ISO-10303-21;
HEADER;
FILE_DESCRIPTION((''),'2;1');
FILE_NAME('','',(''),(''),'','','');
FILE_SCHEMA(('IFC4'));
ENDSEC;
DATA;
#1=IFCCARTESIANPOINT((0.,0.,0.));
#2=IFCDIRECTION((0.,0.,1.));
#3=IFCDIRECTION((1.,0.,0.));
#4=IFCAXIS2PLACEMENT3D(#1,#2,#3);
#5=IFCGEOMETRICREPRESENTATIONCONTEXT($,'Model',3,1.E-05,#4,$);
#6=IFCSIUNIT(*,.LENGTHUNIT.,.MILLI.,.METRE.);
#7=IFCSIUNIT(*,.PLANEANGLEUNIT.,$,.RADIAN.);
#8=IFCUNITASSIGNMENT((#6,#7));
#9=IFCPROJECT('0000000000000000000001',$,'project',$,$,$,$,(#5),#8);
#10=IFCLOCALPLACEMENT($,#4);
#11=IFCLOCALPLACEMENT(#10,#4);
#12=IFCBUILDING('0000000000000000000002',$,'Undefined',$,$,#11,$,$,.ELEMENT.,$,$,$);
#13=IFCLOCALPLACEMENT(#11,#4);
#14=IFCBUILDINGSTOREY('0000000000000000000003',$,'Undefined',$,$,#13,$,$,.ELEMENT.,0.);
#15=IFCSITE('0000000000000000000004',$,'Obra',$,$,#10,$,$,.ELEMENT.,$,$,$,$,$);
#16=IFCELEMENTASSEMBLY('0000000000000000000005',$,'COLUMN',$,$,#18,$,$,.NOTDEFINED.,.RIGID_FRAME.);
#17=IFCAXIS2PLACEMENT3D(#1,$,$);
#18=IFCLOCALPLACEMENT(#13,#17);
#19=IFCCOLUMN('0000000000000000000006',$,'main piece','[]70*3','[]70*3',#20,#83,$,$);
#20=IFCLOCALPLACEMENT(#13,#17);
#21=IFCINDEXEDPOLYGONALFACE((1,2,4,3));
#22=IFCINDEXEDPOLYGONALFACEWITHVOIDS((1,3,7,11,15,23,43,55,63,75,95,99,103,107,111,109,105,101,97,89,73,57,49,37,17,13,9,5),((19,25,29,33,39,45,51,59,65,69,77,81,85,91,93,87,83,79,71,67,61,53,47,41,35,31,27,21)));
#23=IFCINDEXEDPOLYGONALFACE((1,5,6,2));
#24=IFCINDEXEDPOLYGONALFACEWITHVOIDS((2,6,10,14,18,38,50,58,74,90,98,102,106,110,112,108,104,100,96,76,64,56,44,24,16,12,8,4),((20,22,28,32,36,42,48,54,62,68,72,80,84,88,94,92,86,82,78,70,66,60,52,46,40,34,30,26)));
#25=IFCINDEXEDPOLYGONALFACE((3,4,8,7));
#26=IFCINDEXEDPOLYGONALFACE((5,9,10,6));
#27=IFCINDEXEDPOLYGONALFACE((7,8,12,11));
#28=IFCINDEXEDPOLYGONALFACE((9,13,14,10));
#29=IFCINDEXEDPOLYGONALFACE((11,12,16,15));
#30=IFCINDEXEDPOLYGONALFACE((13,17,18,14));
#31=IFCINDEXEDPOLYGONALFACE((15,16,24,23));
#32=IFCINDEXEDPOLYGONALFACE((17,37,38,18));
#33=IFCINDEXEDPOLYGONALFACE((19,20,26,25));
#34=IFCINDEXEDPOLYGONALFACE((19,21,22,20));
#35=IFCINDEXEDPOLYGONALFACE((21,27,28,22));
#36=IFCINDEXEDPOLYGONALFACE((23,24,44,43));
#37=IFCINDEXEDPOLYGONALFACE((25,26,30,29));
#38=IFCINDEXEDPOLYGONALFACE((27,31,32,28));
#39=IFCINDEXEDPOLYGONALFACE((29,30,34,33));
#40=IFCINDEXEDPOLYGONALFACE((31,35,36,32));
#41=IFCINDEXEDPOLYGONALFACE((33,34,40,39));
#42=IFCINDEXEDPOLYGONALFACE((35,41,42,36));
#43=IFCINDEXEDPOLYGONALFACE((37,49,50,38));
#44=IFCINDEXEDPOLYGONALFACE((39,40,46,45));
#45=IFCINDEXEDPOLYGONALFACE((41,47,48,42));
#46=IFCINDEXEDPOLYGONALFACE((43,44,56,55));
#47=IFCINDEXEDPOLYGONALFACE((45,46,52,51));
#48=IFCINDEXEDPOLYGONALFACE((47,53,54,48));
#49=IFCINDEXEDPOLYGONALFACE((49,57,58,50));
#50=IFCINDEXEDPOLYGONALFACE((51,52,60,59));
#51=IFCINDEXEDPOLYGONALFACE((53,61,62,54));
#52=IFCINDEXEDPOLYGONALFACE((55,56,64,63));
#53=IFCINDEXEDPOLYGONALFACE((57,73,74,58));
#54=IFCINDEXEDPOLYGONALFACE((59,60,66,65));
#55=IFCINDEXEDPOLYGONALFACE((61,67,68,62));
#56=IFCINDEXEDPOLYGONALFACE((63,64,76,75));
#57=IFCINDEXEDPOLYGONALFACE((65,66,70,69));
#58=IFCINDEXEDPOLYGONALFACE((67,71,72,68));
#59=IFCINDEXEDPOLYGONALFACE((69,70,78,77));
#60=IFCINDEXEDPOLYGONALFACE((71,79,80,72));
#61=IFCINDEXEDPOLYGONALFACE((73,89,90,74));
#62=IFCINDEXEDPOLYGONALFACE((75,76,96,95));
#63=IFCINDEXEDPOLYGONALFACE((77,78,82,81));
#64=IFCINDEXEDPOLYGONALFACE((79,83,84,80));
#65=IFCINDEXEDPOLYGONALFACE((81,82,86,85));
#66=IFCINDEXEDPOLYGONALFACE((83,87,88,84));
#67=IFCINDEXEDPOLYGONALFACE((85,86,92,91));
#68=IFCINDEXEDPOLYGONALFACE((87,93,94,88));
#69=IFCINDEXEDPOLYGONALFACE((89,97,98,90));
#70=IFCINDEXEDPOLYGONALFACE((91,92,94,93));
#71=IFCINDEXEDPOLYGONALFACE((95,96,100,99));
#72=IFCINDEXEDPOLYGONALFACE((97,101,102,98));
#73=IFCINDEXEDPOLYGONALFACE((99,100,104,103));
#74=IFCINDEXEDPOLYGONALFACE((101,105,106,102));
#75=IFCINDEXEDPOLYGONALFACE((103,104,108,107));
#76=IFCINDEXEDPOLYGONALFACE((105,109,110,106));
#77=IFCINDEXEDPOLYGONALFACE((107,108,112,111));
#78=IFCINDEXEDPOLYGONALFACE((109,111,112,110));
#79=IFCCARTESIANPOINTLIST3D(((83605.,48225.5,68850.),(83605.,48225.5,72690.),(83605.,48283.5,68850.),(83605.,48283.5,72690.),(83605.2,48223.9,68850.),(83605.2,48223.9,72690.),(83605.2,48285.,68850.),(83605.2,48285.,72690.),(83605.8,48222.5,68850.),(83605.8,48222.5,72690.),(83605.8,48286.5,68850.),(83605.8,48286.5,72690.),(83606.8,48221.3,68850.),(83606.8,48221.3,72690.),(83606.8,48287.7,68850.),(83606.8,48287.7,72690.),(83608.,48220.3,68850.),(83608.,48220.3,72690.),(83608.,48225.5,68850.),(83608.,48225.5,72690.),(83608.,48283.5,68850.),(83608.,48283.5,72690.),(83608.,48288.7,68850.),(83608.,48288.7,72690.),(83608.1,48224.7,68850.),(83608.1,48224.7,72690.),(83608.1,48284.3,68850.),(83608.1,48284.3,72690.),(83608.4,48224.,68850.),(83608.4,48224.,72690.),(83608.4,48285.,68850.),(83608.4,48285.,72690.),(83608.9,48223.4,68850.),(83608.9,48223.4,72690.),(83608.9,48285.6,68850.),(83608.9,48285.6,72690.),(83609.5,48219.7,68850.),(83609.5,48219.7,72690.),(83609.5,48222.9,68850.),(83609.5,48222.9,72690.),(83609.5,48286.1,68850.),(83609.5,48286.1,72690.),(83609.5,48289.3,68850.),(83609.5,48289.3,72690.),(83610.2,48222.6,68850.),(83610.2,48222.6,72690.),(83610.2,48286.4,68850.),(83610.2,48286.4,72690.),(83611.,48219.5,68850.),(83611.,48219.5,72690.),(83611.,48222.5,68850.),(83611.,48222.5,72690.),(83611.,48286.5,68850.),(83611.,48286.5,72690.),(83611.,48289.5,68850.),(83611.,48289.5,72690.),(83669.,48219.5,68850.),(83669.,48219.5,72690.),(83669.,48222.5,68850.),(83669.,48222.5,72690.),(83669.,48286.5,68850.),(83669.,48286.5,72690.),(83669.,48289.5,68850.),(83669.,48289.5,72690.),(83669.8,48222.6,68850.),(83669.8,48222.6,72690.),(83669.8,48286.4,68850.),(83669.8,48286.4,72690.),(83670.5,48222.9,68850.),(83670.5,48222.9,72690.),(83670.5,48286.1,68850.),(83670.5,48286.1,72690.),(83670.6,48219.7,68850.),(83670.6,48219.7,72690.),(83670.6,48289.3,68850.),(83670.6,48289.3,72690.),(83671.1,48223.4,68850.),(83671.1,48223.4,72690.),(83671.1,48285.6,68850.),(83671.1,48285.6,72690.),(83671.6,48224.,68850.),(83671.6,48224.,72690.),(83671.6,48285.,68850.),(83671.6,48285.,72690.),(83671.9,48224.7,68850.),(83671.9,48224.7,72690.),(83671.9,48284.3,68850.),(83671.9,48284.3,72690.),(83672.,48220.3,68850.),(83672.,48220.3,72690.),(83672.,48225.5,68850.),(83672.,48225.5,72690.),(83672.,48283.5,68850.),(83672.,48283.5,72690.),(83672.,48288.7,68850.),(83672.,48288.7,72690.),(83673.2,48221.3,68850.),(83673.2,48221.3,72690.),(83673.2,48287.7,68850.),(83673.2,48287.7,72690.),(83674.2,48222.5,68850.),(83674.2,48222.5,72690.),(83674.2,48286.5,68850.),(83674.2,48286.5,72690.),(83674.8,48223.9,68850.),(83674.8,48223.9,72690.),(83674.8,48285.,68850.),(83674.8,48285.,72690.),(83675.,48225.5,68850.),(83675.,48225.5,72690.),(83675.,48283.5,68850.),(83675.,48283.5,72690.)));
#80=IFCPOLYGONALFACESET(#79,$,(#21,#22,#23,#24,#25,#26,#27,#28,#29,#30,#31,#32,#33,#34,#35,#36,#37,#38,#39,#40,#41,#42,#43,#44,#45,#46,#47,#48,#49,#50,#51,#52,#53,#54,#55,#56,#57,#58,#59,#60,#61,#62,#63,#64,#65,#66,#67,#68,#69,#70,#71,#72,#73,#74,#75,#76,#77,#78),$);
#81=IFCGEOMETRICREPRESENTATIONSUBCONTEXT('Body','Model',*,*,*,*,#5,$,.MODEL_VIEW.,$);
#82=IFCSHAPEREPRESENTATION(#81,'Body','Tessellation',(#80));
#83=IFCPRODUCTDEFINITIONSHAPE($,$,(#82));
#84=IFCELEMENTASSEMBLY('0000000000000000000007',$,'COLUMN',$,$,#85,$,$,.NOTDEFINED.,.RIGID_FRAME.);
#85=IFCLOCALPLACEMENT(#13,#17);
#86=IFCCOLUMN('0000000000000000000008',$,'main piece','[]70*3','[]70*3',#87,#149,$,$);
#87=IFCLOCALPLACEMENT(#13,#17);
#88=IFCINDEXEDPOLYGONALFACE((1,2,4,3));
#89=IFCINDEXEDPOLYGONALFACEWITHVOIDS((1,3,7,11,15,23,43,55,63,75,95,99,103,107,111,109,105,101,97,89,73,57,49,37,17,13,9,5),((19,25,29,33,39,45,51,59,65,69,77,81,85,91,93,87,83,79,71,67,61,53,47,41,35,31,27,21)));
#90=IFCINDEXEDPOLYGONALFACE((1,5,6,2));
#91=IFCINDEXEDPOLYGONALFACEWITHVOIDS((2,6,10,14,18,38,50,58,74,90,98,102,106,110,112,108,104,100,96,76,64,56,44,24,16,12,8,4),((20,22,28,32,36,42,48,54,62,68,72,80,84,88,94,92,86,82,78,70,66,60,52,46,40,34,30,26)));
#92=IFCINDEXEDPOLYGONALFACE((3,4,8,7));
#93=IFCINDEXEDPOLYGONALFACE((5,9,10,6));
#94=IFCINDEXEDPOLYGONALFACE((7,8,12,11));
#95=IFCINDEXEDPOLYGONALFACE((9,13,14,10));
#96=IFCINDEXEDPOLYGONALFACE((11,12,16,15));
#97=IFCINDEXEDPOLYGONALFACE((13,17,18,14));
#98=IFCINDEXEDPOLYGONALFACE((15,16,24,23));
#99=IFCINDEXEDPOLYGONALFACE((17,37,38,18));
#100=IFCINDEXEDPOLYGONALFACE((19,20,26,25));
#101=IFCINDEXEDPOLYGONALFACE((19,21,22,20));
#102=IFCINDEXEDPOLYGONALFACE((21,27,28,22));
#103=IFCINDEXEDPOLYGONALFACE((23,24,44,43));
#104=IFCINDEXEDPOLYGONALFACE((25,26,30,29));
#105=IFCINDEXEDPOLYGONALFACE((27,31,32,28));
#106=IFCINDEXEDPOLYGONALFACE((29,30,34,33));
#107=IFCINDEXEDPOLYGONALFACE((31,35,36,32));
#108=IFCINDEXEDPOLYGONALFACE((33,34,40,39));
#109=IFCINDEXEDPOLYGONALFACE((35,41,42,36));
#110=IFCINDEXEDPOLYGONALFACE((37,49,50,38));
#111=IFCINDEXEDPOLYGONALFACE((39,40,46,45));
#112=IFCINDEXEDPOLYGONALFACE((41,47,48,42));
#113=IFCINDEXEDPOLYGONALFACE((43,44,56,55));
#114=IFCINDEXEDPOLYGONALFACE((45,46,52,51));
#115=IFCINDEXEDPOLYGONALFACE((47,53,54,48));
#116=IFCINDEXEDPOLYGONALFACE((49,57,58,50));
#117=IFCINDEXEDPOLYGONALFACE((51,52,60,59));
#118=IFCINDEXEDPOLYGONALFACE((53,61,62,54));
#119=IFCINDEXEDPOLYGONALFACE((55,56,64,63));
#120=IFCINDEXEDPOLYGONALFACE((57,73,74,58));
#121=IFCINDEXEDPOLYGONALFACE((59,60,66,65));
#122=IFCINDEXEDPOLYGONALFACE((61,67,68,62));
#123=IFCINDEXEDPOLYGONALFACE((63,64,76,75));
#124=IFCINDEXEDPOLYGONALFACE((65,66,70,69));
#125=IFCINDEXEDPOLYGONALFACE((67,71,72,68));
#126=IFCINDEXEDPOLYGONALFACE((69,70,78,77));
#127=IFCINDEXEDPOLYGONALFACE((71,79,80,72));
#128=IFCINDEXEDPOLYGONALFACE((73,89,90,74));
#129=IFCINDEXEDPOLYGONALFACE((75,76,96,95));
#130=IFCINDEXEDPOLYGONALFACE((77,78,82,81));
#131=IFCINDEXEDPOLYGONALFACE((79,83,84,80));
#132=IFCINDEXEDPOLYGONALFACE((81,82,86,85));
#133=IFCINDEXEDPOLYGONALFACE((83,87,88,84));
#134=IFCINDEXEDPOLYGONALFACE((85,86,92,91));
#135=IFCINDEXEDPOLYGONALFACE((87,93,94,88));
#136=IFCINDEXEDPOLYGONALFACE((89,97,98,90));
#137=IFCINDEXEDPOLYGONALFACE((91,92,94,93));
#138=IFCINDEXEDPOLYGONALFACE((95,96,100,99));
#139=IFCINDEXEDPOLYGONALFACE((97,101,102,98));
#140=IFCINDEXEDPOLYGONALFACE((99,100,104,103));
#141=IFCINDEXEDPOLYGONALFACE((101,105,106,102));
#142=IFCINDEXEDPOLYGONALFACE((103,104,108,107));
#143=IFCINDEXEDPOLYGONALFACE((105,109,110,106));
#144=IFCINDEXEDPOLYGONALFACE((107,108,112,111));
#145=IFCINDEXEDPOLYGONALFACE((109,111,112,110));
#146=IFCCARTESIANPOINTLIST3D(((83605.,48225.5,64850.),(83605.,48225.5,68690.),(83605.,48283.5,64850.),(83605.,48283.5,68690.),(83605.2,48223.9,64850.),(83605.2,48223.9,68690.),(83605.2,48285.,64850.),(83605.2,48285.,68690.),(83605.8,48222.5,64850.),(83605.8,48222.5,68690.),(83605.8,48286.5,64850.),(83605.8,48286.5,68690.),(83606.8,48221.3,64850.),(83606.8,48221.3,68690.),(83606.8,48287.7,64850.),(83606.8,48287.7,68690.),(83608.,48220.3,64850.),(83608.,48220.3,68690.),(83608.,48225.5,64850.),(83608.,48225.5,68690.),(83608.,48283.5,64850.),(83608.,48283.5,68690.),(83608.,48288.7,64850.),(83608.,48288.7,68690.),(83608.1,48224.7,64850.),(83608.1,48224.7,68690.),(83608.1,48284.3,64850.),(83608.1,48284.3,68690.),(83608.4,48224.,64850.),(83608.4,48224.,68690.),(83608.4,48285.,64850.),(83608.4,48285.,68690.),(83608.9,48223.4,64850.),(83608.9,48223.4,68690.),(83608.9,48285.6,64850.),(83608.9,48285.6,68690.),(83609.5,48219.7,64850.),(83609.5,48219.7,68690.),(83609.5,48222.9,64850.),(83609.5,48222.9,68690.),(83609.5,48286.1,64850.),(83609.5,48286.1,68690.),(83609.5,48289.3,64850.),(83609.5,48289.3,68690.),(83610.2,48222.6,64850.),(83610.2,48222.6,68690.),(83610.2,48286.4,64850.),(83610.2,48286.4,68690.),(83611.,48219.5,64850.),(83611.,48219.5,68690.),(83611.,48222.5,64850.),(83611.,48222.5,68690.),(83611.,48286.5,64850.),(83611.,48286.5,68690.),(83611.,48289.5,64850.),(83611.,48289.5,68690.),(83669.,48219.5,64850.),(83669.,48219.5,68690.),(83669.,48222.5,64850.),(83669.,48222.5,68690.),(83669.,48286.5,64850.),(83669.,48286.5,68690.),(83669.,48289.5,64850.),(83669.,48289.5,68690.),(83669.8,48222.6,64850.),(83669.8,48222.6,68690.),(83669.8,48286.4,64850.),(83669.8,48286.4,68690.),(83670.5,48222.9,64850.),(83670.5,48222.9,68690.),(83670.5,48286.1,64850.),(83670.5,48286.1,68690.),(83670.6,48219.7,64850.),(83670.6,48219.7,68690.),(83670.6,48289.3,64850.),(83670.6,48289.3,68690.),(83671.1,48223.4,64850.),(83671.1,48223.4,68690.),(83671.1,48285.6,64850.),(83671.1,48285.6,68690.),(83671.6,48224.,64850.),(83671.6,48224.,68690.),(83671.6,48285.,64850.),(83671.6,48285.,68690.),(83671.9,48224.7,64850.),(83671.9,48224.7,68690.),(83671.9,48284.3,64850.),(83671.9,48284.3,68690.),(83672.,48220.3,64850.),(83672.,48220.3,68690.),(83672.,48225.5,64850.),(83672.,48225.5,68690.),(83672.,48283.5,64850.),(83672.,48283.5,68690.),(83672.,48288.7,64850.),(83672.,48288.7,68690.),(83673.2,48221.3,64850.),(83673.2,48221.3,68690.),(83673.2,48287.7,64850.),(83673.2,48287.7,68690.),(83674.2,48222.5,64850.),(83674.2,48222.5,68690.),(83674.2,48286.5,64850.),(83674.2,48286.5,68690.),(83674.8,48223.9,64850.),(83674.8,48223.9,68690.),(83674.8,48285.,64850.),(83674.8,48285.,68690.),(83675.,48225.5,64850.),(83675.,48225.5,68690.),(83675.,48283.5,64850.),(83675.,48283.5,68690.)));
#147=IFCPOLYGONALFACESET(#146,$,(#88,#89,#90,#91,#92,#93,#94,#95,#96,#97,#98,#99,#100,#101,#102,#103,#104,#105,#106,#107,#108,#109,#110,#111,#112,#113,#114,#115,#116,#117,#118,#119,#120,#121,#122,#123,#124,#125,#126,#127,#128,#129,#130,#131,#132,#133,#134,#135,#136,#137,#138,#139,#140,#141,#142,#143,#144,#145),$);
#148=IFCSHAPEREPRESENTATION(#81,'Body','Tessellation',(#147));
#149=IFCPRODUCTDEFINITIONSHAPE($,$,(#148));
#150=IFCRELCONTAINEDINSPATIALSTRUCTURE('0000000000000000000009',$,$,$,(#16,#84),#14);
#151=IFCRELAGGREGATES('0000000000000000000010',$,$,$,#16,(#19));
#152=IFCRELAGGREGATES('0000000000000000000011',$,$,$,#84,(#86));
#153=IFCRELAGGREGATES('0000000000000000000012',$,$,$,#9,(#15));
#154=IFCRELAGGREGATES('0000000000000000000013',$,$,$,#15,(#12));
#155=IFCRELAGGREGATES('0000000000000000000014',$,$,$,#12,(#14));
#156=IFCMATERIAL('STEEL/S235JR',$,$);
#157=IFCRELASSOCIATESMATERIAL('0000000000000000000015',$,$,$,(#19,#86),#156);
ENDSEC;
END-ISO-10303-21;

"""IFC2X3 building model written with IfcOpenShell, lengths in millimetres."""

from ifc_helpers import new_model, si_unit, frame, origin_with_axes, origin_2d_with_axis, place, context, subcontext, project, spatial, hollow_rectangle, extrude, material, element, aggregate, save


model = new_model("IFC2X3")

# Units and contexts
model_context = context("Model", 3, precision=1e-05, world=origin_with_axes())
body_context = subcontext(model_context, "Body", "Model", "MODEL_VIEW")
ifc_project = project(units=[si_unit("LENGTHUNIT", "METRE", prefix="MILLI"), si_unit("PLANEANGLEUNIT", "RADIAN")], contexts=[model_context])

# Site, building, storey
site_placement = place(None, origin_with_axes())
site = spatial("IfcSite", under=ifc_project, at=site_placement, Name="Obra", CompositionType="ELEMENT")
building_placement = place(site_placement, origin_with_axes())
building = spatial("IfcBuilding", under=site, at=building_placement, Name="Undefined", CompositionType="ELEMENT")
storey_placement = place(building_placement, origin_with_axes())
storey = spatial("IfcBuildingStorey", under=building, at=storey_placement, Name="Undefined", CompositionType="ELEMENT", Elevation=0.0)

# Element assemblies, columns
assembly_1_placement = place(storey_placement, origin_with_axes())
assembly_1 = element("IfcElementAssembly", 1, at=assembly_1_placement, inside=storey, Name="COLUMN", AssemblyPlace="NOTDEFINED", PredefinedType="RIGID_FRAME")
ifc_material = material(Name="STEEL/S235JR")
column_1_placement = place(assembly_1_placement, frame((83640.0, 48254.5, 68850.0), z_axis=(0.0, 0.0, 1.0), x_axis=(0.0, 1.0, 0.0)))
column_1 = element("IfcColumn", 2, at=column_1_placement, material=ifc_material, Name="main piece", Description="[]70*3", ObjectType="[]70*3", context=body_context, shape_type="SweptSolid", body=[
    extrude(hollow_rectangle(XDim=70.0, YDim=70.0, WallThickness=3.0, InnerFilletRadius=3.0, OuterFilletRadius=6.0, at=origin_2d_with_axis()), frame((0.0, 0.0, 3840.0), z_axis=(0.0, 0.0, -1.0), x_axis=(0.0, 1.0, 0.0)), (0.0, 0.0, 1.0), 3840.0),
])
aggregate(assembly_1, [column_1])
assembly_2_placement = place(storey_placement, origin_with_axes())
assembly_2 = element("IfcElementAssembly", 3, at=assembly_2_placement, inside=storey, Name="COLUMN", AssemblyPlace="NOTDEFINED", PredefinedType="RIGID_FRAME")
column_2_placement = place(assembly_2_placement, frame((83640.0, 48254.5, 64850.0), z_axis=(0.0, 0.0, 1.0), x_axis=(0.0, 1.0, 0.0)))
column_2 = element("IfcColumn", 4, at=column_2_placement, material=ifc_material, Name="main piece", Description="[]70*3", ObjectType="[]70*3", context=body_context, shape_type="SweptSolid", body=[
    extrude(hollow_rectangle(XDim=70.0, YDim=70.0, WallThickness=3.0, InnerFilletRadius=3.0, OuterFilletRadius=6.0, at=origin_2d_with_axis()), frame((0.0, 0.0, 3840.0), z_axis=(0.0, 0.0, -1.0), x_axis=(0.0, 1.0, 0.0)), (0.0, 0.0, 1.0), 3840.0),
])
aggregate(assembly_2, [column_2])

save(model, "model.ifc")
